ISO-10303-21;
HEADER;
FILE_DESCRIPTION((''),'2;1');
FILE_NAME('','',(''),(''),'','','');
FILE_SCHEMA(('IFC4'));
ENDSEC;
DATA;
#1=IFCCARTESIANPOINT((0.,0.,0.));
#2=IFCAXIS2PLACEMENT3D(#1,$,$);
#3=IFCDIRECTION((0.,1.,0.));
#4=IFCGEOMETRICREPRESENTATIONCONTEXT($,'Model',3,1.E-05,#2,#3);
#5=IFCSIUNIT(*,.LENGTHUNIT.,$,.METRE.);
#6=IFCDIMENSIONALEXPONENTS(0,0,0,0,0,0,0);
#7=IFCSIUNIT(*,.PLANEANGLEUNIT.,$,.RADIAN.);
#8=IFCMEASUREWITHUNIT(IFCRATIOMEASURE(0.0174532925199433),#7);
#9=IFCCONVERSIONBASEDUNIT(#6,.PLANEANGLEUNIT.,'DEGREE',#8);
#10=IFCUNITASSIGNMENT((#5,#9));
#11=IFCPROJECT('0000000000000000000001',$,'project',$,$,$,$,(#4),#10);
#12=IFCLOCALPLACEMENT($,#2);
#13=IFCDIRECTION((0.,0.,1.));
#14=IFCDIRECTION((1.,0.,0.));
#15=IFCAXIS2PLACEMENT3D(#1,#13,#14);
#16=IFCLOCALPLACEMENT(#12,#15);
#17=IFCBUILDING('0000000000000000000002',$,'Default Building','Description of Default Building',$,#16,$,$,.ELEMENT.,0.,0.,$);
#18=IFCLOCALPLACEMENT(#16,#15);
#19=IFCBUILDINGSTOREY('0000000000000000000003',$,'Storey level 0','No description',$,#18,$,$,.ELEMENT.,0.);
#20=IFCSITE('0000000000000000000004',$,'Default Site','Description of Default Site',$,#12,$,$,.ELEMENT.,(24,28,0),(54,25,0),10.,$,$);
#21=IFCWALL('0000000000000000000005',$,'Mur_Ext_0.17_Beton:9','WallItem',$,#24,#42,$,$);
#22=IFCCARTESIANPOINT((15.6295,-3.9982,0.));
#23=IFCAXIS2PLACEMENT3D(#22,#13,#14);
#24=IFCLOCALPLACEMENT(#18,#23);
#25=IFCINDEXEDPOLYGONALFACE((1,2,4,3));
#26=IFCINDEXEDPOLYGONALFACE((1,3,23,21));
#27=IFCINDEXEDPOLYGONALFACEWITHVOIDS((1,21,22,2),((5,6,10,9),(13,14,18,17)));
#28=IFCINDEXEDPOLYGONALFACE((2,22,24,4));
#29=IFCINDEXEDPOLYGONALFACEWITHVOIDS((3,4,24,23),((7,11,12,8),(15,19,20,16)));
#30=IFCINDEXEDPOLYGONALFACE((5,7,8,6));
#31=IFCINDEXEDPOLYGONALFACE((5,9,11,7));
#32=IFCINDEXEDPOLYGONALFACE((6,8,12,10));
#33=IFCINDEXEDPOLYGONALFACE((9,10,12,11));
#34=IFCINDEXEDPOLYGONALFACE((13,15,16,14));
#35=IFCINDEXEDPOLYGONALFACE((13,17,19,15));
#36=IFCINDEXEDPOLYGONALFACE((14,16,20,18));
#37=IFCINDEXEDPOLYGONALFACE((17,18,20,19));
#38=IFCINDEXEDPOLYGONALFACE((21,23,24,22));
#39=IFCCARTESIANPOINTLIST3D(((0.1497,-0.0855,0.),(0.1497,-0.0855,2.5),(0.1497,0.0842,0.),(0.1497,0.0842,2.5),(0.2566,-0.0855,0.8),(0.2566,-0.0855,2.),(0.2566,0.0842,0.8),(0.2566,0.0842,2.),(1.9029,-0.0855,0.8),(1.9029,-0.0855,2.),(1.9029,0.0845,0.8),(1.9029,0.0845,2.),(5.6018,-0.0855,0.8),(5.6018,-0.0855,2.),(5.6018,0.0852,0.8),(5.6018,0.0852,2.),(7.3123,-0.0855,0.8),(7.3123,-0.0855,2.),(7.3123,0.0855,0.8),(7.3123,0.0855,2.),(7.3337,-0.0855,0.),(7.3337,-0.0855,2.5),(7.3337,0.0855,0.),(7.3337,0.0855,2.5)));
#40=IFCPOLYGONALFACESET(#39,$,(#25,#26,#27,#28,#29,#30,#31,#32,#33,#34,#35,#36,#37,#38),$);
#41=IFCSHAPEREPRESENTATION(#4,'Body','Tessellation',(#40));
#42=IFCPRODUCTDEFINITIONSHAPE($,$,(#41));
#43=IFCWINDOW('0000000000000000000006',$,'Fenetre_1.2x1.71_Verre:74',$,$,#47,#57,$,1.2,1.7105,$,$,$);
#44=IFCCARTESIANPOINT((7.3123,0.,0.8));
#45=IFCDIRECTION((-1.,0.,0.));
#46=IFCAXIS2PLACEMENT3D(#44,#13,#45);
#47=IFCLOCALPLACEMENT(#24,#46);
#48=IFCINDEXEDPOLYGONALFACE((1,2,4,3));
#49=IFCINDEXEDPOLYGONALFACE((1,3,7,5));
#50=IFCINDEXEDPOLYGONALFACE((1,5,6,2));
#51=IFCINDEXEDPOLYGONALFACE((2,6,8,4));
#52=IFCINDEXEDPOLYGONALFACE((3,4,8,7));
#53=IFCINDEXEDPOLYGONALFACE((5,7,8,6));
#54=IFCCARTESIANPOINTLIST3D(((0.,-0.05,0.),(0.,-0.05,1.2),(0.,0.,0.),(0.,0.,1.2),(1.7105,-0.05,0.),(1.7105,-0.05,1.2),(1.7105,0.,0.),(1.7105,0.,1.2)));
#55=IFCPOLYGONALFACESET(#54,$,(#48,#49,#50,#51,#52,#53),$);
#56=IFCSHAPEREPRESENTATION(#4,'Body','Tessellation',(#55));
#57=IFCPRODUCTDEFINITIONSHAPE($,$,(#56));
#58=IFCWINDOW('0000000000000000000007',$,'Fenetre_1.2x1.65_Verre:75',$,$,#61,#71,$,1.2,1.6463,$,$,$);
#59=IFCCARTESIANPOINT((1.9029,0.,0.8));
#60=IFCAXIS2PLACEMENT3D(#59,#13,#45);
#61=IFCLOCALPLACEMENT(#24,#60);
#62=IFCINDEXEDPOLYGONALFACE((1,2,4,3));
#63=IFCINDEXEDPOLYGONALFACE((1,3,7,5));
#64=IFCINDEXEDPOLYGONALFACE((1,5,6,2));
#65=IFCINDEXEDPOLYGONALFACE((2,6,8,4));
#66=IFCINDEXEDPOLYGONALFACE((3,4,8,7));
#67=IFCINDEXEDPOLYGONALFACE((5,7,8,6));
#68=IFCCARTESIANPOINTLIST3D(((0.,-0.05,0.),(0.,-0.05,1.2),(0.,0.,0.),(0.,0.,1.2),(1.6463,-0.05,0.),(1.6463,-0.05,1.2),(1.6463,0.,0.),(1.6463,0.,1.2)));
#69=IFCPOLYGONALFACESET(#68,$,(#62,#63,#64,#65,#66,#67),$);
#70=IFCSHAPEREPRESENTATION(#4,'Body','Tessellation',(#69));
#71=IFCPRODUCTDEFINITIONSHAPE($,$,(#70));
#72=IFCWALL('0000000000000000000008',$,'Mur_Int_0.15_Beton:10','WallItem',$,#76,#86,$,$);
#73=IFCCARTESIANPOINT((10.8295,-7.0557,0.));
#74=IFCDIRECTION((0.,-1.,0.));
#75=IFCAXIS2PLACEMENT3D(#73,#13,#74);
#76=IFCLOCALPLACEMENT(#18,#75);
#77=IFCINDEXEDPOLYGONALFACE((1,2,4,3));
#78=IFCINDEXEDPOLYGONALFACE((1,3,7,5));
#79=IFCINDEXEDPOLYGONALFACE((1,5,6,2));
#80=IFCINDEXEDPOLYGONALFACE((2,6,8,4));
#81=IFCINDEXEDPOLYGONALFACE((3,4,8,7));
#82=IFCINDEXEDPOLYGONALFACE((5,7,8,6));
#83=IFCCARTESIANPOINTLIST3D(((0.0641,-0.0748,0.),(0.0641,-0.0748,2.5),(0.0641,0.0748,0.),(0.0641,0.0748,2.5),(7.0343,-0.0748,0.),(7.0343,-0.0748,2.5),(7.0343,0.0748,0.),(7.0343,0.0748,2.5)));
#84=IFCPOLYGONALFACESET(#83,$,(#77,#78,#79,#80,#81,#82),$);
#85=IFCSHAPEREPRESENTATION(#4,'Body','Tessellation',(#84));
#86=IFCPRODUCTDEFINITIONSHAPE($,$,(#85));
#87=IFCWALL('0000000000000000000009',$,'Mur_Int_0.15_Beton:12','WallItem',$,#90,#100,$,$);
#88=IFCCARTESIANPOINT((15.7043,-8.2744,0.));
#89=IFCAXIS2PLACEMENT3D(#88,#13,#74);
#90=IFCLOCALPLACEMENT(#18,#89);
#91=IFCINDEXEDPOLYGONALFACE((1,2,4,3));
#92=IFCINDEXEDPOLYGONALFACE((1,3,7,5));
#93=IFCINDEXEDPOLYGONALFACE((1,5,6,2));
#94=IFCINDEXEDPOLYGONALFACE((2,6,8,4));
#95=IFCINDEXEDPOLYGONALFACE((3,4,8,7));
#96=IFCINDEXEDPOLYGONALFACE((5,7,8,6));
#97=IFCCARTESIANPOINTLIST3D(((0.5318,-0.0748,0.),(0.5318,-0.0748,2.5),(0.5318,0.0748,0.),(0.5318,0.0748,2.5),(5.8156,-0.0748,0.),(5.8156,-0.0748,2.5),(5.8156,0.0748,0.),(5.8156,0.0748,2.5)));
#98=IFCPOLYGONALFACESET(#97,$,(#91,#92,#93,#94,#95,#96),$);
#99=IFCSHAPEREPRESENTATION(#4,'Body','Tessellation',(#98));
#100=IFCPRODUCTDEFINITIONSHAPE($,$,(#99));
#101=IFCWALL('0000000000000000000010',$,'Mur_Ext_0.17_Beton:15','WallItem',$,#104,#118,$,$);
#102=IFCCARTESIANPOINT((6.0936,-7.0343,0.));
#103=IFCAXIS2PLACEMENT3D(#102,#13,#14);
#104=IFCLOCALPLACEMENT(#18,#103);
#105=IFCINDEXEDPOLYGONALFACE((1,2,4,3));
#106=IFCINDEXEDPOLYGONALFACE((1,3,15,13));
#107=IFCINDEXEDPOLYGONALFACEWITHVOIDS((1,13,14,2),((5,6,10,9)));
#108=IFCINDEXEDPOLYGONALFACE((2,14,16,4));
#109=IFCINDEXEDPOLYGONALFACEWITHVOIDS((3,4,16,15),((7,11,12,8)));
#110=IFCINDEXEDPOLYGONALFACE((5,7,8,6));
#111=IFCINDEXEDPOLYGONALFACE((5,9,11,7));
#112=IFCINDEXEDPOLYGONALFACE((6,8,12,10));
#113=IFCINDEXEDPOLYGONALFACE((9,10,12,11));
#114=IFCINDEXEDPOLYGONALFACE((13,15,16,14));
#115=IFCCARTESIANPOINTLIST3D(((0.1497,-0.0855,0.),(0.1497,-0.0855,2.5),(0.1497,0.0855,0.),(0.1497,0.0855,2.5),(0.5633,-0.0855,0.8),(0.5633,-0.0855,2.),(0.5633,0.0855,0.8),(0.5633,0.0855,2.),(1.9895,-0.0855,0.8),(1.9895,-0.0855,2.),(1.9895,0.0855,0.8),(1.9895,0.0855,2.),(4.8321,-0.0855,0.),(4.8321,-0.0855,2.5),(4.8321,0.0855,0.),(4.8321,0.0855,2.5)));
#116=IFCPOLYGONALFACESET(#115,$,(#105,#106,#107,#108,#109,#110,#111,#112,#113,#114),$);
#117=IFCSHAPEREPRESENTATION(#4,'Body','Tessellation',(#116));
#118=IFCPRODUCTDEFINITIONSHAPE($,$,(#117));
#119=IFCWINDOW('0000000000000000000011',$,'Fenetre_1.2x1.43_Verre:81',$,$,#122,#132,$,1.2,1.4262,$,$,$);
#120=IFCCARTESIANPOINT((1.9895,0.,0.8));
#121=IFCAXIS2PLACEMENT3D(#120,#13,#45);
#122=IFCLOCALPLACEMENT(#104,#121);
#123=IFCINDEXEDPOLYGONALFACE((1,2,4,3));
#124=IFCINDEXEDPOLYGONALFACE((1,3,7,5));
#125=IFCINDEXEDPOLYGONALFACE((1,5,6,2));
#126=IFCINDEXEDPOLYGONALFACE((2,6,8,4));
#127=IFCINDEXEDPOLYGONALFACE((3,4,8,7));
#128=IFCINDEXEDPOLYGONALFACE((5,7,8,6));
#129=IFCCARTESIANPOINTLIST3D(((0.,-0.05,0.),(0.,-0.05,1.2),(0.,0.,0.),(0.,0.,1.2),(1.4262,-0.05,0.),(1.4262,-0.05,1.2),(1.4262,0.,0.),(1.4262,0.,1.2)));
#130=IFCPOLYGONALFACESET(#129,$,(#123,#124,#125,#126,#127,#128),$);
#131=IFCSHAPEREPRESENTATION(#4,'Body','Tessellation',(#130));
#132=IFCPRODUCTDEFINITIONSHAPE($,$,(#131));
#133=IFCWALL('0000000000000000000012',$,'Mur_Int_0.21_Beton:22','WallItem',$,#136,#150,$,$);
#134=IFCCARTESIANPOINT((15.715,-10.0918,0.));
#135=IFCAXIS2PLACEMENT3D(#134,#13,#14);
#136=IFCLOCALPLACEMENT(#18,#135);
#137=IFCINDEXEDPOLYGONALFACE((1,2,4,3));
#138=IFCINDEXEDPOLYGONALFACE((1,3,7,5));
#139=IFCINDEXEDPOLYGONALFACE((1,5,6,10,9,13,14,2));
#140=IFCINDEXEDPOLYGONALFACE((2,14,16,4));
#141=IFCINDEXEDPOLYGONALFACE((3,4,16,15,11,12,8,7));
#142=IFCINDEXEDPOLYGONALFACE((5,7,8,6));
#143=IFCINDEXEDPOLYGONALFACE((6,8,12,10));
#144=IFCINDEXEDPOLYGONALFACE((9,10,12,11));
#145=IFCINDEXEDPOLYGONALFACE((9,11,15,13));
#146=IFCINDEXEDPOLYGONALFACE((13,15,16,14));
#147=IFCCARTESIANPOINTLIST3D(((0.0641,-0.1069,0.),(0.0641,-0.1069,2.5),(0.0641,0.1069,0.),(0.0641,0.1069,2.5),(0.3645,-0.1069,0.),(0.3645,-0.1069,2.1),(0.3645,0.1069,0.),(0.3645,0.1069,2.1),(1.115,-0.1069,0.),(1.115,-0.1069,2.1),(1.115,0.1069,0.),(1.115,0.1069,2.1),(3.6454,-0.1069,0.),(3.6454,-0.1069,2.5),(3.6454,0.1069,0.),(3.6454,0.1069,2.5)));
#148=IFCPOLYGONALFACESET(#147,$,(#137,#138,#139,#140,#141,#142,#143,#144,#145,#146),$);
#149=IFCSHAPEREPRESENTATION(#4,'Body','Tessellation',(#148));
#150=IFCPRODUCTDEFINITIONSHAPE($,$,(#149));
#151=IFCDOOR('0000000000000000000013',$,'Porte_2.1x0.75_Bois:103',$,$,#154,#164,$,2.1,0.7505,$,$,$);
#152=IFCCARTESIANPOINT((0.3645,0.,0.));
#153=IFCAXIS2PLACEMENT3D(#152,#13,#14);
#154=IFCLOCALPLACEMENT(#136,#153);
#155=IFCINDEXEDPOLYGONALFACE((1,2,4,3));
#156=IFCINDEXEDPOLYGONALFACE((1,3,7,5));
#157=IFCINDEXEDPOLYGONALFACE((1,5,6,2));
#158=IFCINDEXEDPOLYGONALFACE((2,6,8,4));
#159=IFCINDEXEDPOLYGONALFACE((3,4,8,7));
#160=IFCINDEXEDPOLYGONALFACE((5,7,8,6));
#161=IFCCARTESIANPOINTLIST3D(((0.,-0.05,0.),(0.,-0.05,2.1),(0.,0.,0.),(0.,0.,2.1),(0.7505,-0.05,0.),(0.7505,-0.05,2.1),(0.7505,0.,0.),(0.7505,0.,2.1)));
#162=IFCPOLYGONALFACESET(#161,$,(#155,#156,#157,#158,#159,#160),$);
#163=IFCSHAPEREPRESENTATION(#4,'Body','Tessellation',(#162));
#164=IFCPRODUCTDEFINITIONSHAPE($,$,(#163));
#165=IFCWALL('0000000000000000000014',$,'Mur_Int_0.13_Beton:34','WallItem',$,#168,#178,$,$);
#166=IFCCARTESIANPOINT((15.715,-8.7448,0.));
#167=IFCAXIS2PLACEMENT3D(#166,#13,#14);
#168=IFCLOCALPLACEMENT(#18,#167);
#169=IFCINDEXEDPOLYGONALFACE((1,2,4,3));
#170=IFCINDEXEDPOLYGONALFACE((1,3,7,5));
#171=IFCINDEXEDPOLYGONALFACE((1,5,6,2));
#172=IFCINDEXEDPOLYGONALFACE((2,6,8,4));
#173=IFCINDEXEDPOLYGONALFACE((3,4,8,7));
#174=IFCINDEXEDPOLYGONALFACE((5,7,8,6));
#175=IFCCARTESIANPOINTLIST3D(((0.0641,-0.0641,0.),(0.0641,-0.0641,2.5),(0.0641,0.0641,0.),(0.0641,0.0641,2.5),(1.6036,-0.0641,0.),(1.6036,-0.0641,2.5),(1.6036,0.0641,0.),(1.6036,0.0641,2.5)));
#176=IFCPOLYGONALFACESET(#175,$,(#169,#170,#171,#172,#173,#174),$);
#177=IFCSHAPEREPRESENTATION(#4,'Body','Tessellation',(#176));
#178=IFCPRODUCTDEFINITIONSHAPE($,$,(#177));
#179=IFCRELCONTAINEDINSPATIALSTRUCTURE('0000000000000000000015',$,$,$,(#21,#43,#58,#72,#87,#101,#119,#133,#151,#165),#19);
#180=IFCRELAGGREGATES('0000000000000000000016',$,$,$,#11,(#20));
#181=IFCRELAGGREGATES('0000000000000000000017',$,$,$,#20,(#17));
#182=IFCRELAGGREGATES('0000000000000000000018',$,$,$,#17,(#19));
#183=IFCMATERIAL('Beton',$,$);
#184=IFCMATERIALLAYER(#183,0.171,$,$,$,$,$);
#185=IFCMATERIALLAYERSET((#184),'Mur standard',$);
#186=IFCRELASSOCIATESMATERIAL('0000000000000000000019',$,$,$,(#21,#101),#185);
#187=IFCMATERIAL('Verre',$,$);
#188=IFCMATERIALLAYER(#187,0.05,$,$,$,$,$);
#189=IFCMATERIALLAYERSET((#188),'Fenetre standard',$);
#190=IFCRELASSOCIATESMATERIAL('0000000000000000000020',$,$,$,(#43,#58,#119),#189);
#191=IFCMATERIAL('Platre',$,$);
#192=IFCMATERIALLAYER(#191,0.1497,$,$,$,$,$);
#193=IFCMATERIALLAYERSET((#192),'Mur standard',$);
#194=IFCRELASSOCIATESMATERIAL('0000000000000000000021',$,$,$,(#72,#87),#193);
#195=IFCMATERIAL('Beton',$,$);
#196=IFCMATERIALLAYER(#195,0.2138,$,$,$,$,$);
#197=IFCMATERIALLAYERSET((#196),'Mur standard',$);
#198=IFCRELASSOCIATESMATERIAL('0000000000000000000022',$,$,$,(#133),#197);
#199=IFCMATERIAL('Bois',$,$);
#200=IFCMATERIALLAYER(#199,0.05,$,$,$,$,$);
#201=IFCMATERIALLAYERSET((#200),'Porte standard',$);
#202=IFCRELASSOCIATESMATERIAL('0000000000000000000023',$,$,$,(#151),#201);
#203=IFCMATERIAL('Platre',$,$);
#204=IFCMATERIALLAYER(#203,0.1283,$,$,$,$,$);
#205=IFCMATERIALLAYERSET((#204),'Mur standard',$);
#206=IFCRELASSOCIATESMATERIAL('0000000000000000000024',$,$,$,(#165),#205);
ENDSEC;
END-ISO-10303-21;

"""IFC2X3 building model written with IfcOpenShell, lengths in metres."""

from ifc_helpers import new_model, entity, si_unit, converted_unit, direction, frame, origin, origin_with_axes, place, context, project, spatial, polyline, outline, extrude, material, layer, layer_set, layer_usage, element, fill, save


model = new_model("IFC2X3")

# Units and contexts
model_context = context("Model", 3, precision=1e-05, world=origin(), true_north=direction((0.0, 1.0, 0.0)))
ifc_project = project(units=[si_unit("LENGTHUNIT", "METRE"), converted_unit("PLANEANGLEUNIT", "DEGREE", entity("IfcRatioMeasure", 0.0174532925199433), si_unit("PLANEANGLEUNIT", "RADIAN"), dimensions=[0, 0, 0, 0, 0, 0, 0])], contexts=[model_context])

# Site, building, storey
site_placement = place(None, origin())
site = spatial("IfcSite", under=ifc_project, at=site_placement, Name="Default Site", Description="Description of Default Site", CompositionType="ELEMENT", RefLatitude=(24, 28, 0), RefLongitude=(54, 25, 0), RefElevation=10.0)
building_placement = place(site_placement, origin_with_axes())
building = spatial("IfcBuilding", under=site, at=building_placement, Name="Default Building", Description="Description of Default Building", CompositionType="ELEMENT", ElevationOfRefHeight=0.0, ElevationOfTerrain=0.0)
storey_placement = place(building_placement, origin_with_axes())
storey = spatial("IfcBuildingStorey", under=building, at=storey_placement, Name="Storey level 0", Description="No description", CompositionType="ELEMENT", Elevation=0.0)

# Shared definitions
ifc_material_1 = material(Name="Beton")
ifc_layer_1 = layer(ifc_material_1, 0.171)
ifc_layer_set_1 = layer_set([ifc_layer_1], Name="Mur standard")
ifc_layer_usage_1 = layer_usage(ifc_layer_set_1, "AXIS2", "NEGATIVE", 0.171)
ifc_material_2 = material(Name="Verre")
ifc_layer_2 = layer(ifc_material_2, 0.05)
ifc_layer_set_2 = layer_set([ifc_layer_2], Name="Fenetre standard")
ifc_layer_usage_2 = layer_usage(ifc_layer_set_2, "AXIS2", "NEGATIVE", 0.05)
ifc_material_3 = material(Name="Bois")
ifc_layer_3 = layer(ifc_material_3, 0.05)
ifc_layer_set_3 = layer_set([ifc_layer_3], Name="Porte standard")
ifc_layer_usage_3 = layer_usage(ifc_layer_set_3, "AXIS2", "NEGATIVE", 0.05)

# Wall, openings, windows
wall_1_placement = place(storey_placement, frame((15.6295, -3.9982, 0.0), z_axis=(0.0, 0.0, 1.0), x_axis=(1.0, 0.0, 0.0)))
wall_1 = element("IfcWall", 1, at=wall_1_placement, inside=storey, material=ifc_layer_usage_1, Name="Mur_Ext_0.17_Beton:9", Description="WallItem", context=model_context, shape_type="SweptSolid", body=[
    extrude(outline(polyline([(7.3337, -0.0855), (0.1497, -0.0855), (0.1497, 0.0842), (7.3337, 0.0855), (7.3337, -0.0855)])), origin(), (0.0, 0.0, 1.0), 2.5),
])
opening_1_placement = place(storey_placement, frame((22.9418, -3.9127, 0.8), z_axis=(0.0, 0.0, 1.0), x_axis=(-1.0, 0.0, 0.0)))
opening_1 = element("IfcOpeningElement", 2, at=opening_1_placement, cuts=wall_1, context=model_context, shape_type="SweptSolid", body=[
    extrude(outline(polyline([(1.7105, 0.221), (0.0, 0.221), (0.0, -0.05), (1.7105, -0.05), (1.7105, 0.221)])), origin(), (0.0, 0.0, 1.0), 1.2),
])
opening_2_placement = place(storey_placement, frame((17.5324, -3.9127, 0.8), z_axis=(0.0, 0.0, 1.0), x_axis=(-1.0, 0.0, 0.0)))
opening_2 = element("IfcOpeningElement", 3, at=opening_2_placement, cuts=wall_1, context=model_context, shape_type="SweptSolid", body=[
    extrude(outline(polyline([(1.6463, 0.221), (0.0, 0.221), (0.0, -0.05), (1.6463, -0.05), (1.6463, 0.221)])), origin(), (0.0, 0.0, 1.0), 1.2),
])
window_1_placement = place(wall_1_placement, frame((7.3123, 0.0, 0.8), z_axis=(0.0, 0.0, 1.0), x_axis=(-1.0, 0.0, 0.0)))
window_1 = element("IfcWindow", 4, at=window_1_placement, inside=storey, material=ifc_layer_usage_2, Name="Fenetre_1.2x1.71_Verre:74", OverallHeight=1.2, OverallWidth=1.7105, context=model_context, shape_type="SweptSolid", body=[
    extrude(outline(polyline([(0.0, 0.0), (1.7105, 0.0), (1.7105, -0.05), (0.0, -0.05), (0.0, 0.0)])), origin(), (0.0, 0.0, 1.0), 1.2),
])
fill(opening_1, window_1)
window_2_placement = place(wall_1_placement, frame((1.9029, 0.0, 0.8), z_axis=(0.0, 0.0, 1.0), x_axis=(-1.0, 0.0, 0.0)))
window_2 = element("IfcWindow", 5, at=window_2_placement, inside=storey, material=ifc_layer_usage_2, Name="Fenetre_1.2x1.65_Verre:75", OverallHeight=1.2, OverallWidth=1.6463, context=model_context, shape_type="SweptSolid", body=[
    extrude(outline(polyline([(0.0, 0.0), (1.6463, 0.0), (1.6463, -0.05), (0.0, -0.05), (0.0, 0.0)])), origin(), (0.0, 0.0, 1.0), 1.2),
])
fill(opening_2, window_2)

# Walls
ifc_material_4 = material(Name="Platre")
ifc_layer_4 = layer(ifc_material_4, 0.1497)
ifc_layer_set_4 = layer_set([ifc_layer_4], Name="Mur standard")
ifc_layer_usage_4 = layer_usage(ifc_layer_set_4, "AXIS2", "NEGATIVE", 0.1497)
wall_2_placement = place(storey_placement, frame((10.8295, -7.0557, 0.0), z_axis=(0.0, 0.0, 1.0), x_axis=(0.0, -1.0, 0.0)))
element("IfcWall", 6, at=wall_2_placement, inside=storey, material=ifc_layer_usage_4, Name="Mur_Int_0.15_Beton:10", Description="WallItem", context=model_context, shape_type="SweptSolid", body=[
    extrude(outline(polyline([(0.0641, -0.0748), (7.0343, -0.0748), (7.0343, 0.0748), (0.0641, 0.0748), (0.0641, -0.0748)])), origin(), (0.0, 0.0, 1.0), 2.5),
])
wall_3_placement = place(storey_placement, frame((15.7043, -8.2744, 0.0), z_axis=(0.0, 0.0, 1.0), x_axis=(0.0, -1.0, 0.0)))
element("IfcWall", 7, at=wall_3_placement, inside=storey, material=ifc_layer_usage_4, Name="Mur_Int_0.15_Beton:12", Description="WallItem", context=model_context, shape_type="SweptSolid", body=[
    extrude(outline(polyline([(0.5318, -0.0748), (5.8156, -0.0748), (5.8156, 0.0748), (0.5318, 0.0748), (0.5318, -0.0748)])), origin(), (0.0, 0.0, 1.0), 2.5),
])

# Wall, opening, window
wall_4_placement = place(storey_placement, frame((6.0936, -7.0343, 0.0), z_axis=(0.0, 0.0, 1.0), x_axis=(1.0, 0.0, 0.0)))
wall_4 = element("IfcWall", 8, at=wall_4_placement, inside=storey, material=ifc_layer_usage_1, Name="Mur_Ext_0.17_Beton:15", Description="WallItem", context=model_context, shape_type="SweptSolid", body=[
    extrude(outline(polyline([(0.1497, 0.0855), (0.1497, -0.0855), (4.8321, -0.0855), (4.8321, 0.0855), (0.1497, 0.0855)])), origin(), (0.0, 0.0, 1.0), 2.5),
])
opening_3_placement = place(storey_placement, frame((8.0831, -6.9488, 0.8), z_axis=(0.0, 0.0, 1.0), x_axis=(-1.0, 0.0, 0.0)))
opening_3 = element("IfcOpeningElement", 9, at=opening_3_placement, cuts=wall_4, context=model_context, shape_type="SweptSolid", body=[
    extrude(outline(polyline([(1.4262, 0.221), (0.0, 0.221), (0.0, -0.05), (1.4262, -0.05), (1.4262, 0.221)])), origin(), (0.0, 0.0, 1.0), 1.2),
])
window_3_placement = place(wall_4_placement, frame((1.9895, 0.0, 0.8), z_axis=(0.0, 0.0, 1.0), x_axis=(-1.0, 0.0, 0.0)))
window_3 = element("IfcWindow", 10, at=window_3_placement, inside=storey, material=ifc_layer_usage_2, Name="Fenetre_1.2x1.43_Verre:81", OverallHeight=1.2, OverallWidth=1.4262, context=model_context, shape_type="SweptSolid", body=[
    extrude(outline(polyline([(0.0, 0.0), (1.4262, 0.0), (1.4262, -0.05), (0.0, -0.05), (0.0, 0.0)])), origin(), (0.0, 0.0, 1.0), 1.2),
])
fill(opening_3, window_3)

# Wall, opening, door
ifc_material_5 = material(Name="Beton")
ifc_layer_5 = layer(ifc_material_5, 0.2138)
ifc_layer_set_5 = layer_set([ifc_layer_5], Name="Mur standard")
ifc_layer_usage_5 = layer_usage(ifc_layer_set_5, "AXIS2", "NEGATIVE", 0.2138)
wall_5_placement = place(storey_placement, frame((15.715, -10.0918, 0.0), z_axis=(0.0, 0.0, 1.0), x_axis=(1.0, 0.0, 0.0)))
wall_5 = element("IfcWall", 11, at=wall_5_placement, inside=storey, material=ifc_layer_usage_5, Name="Mur_Int_0.21_Beton:22", Description="WallItem", context=model_context, shape_type="SweptSolid", body=[
    extrude(outline(polyline([(0.0641, 0.1069), (0.0641, -0.1069), (3.6454, -0.1069), (3.6454, 0.1069), (0.0641, 0.1069)])), origin(), (0.0, 0.0, 1.0), 2.5),
])
opening_4_placement = place(storey_placement, frame((16.0795, -9.9849, 0.0), z_axis=(0.0, 0.0, 1.0), x_axis=(1.0, 0.0, 0.0)))
opening_4 = element("IfcOpeningElement", 12, at=opening_4_placement, cuts=wall_5, context=model_context, shape_type="SweptSolid", body=[
    extrude(outline(polyline([(0.0, -0.2638), (0.7505, -0.2638), (0.7505, 0.05), (0.0, 0.05), (0.0, -0.2638)])), origin(), (0.0, 0.0, 1.0), 2.1),
])
door_1_placement = place(wall_5_placement, frame((0.3645, 0.0, 0.0), z_axis=(0.0, 0.0, 1.0), x_axis=(1.0, 0.0, 0.0)))
door_1 = element("IfcDoor", 13, at=door_1_placement, inside=storey, material=ifc_layer_usage_3, Name="Porte_2.1x0.75_Bois:103", OverallHeight=2.1, OverallWidth=0.7505, context=model_context, shape_type="SweptSolid", body=[
    extrude(outline(polyline([(0.0, 0.0), (0.7505, 0.0), (0.7505, -0.05), (0.0, -0.05), (0.0, 0.0)])), origin(), (0.0, 0.0, 1.0), 2.1),
])
fill(opening_4, door_1)

# Wall
ifc_material_6 = material(Name="Platre")
ifc_layer_6 = layer(ifc_material_6, 0.1283)
ifc_layer_set_6 = layer_set([ifc_layer_6], Name="Mur standard")
ifc_layer_usage_6 = layer_usage(ifc_layer_set_6, "AXIS2", "NEGATIVE", 0.1283)
wall_6_placement = place(storey_placement, frame((15.715, -8.7448, 0.0), z_axis=(0.0, 0.0, 1.0), x_axis=(1.0, 0.0, 0.0)))
element("IfcWall", 14, at=wall_6_placement, inside=storey, material=ifc_layer_usage_6, Name="Mur_Int_0.13_Beton:34", Description="WallItem", context=model_context, shape_type="SweptSolid", body=[
    extrude(outline(polyline([(1.6036, -0.0641), (0.0641, -0.0641), (0.0641, 0.0641), (1.6036, 0.0641), (1.6036, -0.0641)])), origin(), (0.0, 0.0, 1.0), 2.5),
])

save(model, "model.ifc")
